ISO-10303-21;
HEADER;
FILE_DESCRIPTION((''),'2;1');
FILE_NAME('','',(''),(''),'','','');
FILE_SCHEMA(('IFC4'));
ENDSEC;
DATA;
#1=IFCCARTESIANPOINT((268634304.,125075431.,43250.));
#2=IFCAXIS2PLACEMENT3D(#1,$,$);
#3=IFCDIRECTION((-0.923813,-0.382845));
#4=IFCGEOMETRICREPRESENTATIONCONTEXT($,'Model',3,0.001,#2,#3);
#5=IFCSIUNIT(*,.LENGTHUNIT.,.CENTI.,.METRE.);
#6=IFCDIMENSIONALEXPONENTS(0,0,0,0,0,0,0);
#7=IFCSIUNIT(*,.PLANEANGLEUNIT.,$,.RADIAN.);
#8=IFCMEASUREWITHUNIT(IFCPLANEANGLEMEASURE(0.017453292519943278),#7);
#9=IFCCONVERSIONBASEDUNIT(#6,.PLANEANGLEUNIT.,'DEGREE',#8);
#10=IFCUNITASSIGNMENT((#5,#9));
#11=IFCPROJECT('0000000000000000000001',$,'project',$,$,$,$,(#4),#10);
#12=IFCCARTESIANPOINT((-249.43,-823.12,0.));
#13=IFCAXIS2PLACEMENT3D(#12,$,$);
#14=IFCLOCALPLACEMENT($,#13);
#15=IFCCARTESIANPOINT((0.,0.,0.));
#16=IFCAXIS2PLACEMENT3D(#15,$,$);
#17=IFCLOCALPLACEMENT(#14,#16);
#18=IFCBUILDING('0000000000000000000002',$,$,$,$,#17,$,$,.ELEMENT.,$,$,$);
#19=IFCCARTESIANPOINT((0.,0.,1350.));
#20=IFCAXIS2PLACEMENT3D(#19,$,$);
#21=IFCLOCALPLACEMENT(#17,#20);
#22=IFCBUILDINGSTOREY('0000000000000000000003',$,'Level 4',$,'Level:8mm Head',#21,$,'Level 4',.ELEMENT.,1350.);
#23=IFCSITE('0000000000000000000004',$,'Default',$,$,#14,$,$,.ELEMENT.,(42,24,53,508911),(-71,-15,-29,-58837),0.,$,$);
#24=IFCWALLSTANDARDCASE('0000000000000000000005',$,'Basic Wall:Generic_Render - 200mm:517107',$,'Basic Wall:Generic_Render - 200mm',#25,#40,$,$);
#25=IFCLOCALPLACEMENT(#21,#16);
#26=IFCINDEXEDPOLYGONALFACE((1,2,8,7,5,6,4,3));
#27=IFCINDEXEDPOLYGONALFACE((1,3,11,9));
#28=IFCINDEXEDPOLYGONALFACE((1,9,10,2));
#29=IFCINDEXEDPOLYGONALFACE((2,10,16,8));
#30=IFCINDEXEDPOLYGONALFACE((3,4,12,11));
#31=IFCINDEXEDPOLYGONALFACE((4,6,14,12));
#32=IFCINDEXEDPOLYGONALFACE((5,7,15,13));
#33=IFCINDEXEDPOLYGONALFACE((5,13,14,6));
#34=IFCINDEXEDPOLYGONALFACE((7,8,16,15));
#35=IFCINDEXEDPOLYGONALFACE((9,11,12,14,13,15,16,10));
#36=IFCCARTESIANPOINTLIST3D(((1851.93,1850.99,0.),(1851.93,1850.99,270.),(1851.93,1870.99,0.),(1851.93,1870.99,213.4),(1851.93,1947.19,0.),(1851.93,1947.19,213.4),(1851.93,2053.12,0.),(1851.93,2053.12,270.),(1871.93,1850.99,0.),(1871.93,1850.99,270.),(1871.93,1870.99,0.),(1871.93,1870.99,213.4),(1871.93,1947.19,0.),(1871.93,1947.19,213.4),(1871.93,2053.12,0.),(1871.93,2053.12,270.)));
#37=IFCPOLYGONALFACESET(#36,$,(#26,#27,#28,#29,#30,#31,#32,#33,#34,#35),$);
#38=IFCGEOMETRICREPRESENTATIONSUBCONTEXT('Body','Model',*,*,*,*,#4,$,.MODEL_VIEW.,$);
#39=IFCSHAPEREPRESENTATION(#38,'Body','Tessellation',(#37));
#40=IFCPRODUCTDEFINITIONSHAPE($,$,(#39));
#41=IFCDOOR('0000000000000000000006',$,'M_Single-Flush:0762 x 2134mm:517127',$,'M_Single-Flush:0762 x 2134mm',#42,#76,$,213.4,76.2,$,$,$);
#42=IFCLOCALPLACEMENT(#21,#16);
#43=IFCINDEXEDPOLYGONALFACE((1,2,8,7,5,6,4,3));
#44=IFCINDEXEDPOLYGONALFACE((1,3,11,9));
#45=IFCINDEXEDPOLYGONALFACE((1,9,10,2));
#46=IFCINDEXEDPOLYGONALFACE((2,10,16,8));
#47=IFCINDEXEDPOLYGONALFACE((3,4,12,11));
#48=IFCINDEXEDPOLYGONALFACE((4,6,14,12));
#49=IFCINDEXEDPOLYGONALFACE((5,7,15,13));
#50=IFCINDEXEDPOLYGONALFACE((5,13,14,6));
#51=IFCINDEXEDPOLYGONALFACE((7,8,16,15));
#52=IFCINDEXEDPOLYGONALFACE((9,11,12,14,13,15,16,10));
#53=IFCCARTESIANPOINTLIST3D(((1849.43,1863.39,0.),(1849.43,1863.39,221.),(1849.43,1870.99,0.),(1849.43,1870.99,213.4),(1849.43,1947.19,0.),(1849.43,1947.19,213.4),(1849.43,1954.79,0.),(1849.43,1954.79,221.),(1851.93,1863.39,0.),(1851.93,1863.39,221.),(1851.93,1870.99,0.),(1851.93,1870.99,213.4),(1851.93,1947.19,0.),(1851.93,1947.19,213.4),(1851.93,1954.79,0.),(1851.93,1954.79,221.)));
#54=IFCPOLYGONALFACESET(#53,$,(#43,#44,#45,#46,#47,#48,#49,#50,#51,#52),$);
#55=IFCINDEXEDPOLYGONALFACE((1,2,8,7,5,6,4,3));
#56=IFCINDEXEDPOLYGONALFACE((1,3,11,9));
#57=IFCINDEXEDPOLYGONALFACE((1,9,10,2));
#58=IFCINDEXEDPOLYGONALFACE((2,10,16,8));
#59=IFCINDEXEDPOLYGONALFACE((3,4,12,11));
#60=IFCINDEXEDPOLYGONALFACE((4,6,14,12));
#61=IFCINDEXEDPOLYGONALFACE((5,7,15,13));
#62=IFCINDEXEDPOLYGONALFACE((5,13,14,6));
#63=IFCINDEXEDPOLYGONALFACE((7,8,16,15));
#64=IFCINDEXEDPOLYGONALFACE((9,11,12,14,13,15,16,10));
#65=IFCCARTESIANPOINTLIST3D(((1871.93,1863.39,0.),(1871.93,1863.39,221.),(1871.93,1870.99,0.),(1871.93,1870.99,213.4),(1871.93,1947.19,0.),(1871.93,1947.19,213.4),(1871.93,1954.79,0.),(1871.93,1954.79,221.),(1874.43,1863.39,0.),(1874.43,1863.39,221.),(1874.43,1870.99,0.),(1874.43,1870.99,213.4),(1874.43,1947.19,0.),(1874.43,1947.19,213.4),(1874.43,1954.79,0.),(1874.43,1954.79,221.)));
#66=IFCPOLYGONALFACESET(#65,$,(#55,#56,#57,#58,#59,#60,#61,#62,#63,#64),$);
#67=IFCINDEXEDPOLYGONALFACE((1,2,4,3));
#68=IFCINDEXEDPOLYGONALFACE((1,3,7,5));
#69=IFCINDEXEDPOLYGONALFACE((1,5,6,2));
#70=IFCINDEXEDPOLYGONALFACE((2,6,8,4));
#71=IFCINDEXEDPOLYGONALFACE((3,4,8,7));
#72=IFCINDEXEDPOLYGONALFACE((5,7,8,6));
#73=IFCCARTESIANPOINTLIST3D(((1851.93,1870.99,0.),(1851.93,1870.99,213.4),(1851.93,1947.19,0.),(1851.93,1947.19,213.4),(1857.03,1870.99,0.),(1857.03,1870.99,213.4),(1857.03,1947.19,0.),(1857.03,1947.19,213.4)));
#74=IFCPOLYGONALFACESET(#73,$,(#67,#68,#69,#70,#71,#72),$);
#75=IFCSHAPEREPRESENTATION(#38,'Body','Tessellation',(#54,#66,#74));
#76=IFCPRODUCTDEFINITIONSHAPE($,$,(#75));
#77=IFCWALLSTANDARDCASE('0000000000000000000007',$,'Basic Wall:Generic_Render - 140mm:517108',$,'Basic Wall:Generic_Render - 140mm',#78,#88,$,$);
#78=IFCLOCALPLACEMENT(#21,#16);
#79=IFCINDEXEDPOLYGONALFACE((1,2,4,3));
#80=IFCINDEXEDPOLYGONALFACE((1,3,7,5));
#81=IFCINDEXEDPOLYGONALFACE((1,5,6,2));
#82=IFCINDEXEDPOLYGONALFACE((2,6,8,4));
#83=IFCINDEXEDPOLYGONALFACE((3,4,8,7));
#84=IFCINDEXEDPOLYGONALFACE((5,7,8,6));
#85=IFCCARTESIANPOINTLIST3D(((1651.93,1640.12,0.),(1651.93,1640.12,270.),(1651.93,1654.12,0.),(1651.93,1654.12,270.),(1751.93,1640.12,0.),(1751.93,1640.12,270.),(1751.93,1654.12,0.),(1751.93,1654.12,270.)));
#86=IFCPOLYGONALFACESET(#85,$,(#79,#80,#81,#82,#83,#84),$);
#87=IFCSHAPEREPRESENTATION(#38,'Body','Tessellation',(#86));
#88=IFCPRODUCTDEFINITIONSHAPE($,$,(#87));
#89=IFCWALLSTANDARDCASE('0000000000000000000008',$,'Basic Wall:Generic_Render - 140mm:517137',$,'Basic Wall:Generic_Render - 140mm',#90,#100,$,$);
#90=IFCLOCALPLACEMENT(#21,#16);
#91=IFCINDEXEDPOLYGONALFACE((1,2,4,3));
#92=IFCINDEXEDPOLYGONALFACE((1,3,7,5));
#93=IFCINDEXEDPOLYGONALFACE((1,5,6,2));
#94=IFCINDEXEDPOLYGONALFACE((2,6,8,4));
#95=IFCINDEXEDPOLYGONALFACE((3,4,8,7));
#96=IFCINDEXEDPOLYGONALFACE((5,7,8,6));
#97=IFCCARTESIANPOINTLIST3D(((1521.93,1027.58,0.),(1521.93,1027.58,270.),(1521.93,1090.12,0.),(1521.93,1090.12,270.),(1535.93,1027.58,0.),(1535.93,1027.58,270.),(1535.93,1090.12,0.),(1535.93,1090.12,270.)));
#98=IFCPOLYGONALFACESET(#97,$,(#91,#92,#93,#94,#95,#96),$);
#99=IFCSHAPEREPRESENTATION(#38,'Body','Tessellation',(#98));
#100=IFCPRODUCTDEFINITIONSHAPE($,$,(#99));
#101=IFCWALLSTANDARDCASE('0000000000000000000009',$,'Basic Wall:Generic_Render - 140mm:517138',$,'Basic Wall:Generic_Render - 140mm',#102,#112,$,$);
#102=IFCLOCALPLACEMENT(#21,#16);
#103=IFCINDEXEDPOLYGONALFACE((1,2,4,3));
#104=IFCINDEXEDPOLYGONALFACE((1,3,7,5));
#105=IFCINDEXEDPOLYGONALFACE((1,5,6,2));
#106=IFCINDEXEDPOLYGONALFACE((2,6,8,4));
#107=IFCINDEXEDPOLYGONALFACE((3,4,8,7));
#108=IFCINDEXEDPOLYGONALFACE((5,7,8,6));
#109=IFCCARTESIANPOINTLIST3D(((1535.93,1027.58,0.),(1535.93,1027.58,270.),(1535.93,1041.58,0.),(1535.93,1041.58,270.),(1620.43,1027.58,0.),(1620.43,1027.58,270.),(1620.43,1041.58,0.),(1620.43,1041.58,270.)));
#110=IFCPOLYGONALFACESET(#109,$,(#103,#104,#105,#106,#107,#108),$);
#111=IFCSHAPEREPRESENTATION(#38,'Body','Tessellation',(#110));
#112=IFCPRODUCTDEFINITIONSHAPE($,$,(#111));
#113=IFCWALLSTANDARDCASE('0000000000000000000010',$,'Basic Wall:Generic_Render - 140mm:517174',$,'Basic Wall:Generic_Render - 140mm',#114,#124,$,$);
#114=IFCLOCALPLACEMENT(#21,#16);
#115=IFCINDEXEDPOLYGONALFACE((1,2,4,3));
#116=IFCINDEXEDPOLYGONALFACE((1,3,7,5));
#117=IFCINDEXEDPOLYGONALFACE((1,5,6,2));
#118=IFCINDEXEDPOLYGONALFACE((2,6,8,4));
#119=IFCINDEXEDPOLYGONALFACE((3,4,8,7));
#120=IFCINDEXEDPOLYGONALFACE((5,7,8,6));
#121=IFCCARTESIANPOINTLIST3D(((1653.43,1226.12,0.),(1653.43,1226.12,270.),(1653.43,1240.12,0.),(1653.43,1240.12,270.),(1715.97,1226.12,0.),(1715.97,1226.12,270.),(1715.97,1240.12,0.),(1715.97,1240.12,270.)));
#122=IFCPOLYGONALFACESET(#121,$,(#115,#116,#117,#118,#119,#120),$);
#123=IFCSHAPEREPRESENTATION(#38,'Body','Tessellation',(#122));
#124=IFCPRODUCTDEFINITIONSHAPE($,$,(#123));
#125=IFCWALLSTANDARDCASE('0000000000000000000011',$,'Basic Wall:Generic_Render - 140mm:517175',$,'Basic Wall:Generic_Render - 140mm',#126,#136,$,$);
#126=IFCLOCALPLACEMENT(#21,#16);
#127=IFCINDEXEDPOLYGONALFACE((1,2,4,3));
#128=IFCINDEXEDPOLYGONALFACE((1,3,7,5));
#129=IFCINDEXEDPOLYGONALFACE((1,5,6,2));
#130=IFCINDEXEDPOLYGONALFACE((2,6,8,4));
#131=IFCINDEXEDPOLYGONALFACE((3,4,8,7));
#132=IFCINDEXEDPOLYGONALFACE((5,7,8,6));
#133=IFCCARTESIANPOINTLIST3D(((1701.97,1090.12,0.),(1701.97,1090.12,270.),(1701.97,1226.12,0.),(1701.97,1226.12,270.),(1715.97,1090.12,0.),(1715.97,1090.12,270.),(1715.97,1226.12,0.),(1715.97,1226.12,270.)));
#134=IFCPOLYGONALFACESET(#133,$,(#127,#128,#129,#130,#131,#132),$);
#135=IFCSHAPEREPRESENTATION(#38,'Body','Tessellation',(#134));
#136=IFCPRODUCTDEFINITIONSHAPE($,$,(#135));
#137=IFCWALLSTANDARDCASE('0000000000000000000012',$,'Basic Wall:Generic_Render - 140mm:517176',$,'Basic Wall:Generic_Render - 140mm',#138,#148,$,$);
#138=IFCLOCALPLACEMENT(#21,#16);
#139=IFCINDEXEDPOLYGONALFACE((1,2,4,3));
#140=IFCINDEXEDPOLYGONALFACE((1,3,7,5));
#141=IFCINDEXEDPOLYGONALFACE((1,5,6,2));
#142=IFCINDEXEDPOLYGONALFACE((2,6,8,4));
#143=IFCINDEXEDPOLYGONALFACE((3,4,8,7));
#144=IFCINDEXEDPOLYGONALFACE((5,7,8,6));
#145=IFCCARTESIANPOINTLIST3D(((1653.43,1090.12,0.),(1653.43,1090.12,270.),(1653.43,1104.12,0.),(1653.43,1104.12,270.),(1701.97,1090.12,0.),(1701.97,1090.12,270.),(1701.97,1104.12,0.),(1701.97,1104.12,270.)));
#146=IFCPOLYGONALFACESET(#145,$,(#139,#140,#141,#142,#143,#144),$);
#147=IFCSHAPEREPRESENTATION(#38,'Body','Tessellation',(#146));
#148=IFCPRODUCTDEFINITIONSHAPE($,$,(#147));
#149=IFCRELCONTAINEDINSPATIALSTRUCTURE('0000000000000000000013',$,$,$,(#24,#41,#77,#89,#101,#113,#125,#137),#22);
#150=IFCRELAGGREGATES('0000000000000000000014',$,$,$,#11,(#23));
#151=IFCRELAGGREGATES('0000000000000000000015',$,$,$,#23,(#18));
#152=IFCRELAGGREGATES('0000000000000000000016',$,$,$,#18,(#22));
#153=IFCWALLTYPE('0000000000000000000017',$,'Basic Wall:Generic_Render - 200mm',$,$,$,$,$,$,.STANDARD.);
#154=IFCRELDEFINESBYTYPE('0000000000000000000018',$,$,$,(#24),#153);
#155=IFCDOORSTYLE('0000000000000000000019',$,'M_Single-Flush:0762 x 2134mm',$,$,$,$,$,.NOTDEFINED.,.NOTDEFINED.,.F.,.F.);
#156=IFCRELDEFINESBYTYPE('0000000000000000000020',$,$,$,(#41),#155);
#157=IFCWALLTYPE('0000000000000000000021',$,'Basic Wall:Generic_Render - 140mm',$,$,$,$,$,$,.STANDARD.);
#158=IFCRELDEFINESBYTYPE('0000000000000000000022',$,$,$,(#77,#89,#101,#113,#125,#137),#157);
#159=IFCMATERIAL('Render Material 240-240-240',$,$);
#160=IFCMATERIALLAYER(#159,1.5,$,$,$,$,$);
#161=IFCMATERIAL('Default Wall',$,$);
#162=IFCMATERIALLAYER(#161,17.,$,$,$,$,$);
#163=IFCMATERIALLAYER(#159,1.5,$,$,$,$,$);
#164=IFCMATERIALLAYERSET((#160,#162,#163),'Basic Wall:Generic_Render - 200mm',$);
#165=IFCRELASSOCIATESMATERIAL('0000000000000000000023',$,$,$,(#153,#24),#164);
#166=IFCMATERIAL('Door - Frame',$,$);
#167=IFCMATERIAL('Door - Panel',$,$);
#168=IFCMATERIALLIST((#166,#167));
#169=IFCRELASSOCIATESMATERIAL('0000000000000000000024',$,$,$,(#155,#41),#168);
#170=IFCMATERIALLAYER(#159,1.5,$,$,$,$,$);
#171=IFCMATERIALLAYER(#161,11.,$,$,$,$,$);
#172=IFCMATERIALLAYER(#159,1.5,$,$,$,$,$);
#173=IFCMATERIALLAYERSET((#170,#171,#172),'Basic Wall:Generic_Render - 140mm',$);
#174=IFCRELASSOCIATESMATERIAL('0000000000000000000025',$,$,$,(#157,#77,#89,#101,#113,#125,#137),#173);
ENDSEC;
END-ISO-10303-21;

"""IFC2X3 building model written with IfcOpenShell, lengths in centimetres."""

from ifc_helpers import new_model, entity, si_unit, converted_unit, direction, frame, frame_2d, origin, place, context, subcontext, project, spatial, polyline, rectangle, outline, extrude, source, transform, mapped, material, material_list, layer, layer_set, layer_usage, type_object, type_shapes, element, fill, save


model = new_model("IFC2X3")

# Units and contexts
model_context = context("Model", 3, precision=0.001, world=frame((268634304.0, 125075431.0, 43250.0)), true_north=direction((-0.923813, -0.382845)))
body_context = subcontext(model_context, "Body", "Model", "MODEL_VIEW")
ifc_project = project(units=[si_unit("LENGTHUNIT", "METRE", prefix="CENTI"), converted_unit("PLANEANGLEUNIT", "DEGREE", entity("IfcPlaneAngleMeasure", 0.017453292519943278), si_unit("PLANEANGLEUNIT", "RADIAN"), dimensions=[0, 0, 0, 0, 0, 0, 0])], contexts=[model_context])

# Site, building, storey
site_placement = place(None, frame((-249.43, -823.12, 0.0)))
site = spatial("IfcSite", under=ifc_project, at=site_placement, Name="Default", CompositionType="ELEMENT", RefLatitude=(42, 24, 53, 508911), RefLongitude=(-71, -15, -29, -58837), RefElevation=0.0)
building_placement = place(site_placement, origin())
building = spatial("IfcBuilding", under=site, at=building_placement, CompositionType="ELEMENT")
storey_placement = place(building_placement, frame((0.0, 0.0, 1350.0)))
storey = spatial("IfcBuildingStorey", under=building, at=storey_placement, Name="Level 4", ObjectType="Level:8mm Head", LongName="Level 4", CompositionType="ELEMENT", Elevation=1350.0)

# Shared definitions
ifc_material_1 = material(Name="Render Material 240-240-240")
ifc_material_2 = material(Name="Default Wall")
ifc_layer_1 = layer(ifc_material_1, 1.5)
ifc_layer_2 = layer(ifc_material_2, 17.0)
ifc_layer_3 = layer(ifc_material_1, 1.5)
ifc_layer_set_1 = layer_set([ifc_layer_1, ifc_layer_2, ifc_layer_3], Name="Basic Wall:Generic_Render - 200mm")
wall_type_1 = type_object("IfcWallType", Name="Basic Wall:Generic_Render - 200mm", PredefinedType="STANDARD", material=ifc_layer_set_1)

# Shared definitions
ifc_material_3 = material(Name="Door - Frame")
ifc_material_4 = material(Name="Door - Panel")
ifc_material_list_1 = material_list([ifc_material_3, ifc_material_4])

# Wall, opening, door
ifc_layer_usage_1 = layer_usage(ifc_layer_set_1, "AXIS2", "NEGATIVE", 10.0)
wall_1_placement = place(storey_placement, frame((1861.93, 1850.99, 0.0), z_axis=(0.0, 0.0, 1.0), x_axis=(0.0, 1.0, 0.0)))
wall_1 = element("IfcWallStandardCase", 1, at=wall_1_placement, inside=storey, type_object=wall_type_1, material=ifc_layer_usage_1, Name="Basic Wall:Generic_Render - 200mm:517107", ObjectType="Basic Wall:Generic_Render - 200mm", context=body_context, shape_type="SweptSolid", body=[
    extrude(rectangle(XDim=202.14, YDim=20.0, at=frame_2d((101.07, 0.0), x_axis=(1.0, 0.0))), origin(), (0.0, 0.0, 1.0), 270.0),
])
opening_1_placement = place(wall_1_placement, frame((20.0, -10.0, 0.0)))
opening_1 = element("IfcOpeningElement", 2, at=opening_1_placement, cuts=wall_1, ObjectType="Opening", context=body_context, shape_type="SweptSolid", body=[
    extrude(rectangle(XDim=76.2, YDim=213.4, at=frame_2d((106.7, 38.1), x_axis=(0.0, -1.0))), frame((0.0, 0.0, 0.0), z_axis=(0.0, 1.0, 0.0), x_axis=(0.0, 0.0, 1.0)), (0.0, 0.0, 1.0), 20.0),
])
door_style_1 = type_object("IfcDoorStyle", Name="M_Single-Flush:0762 x 2134mm", ConstructionType="NOTDEFINED", OperationType="NOTDEFINED", ParameterTakesPrecedence=False, Sizeable=False, material=ifc_material_list_1)
shared_shape_1 = source(origin(), body_context, "Body", "SweptSolid", [
    extrude(outline(polyline([(-45.7, -112.4), (45.7, -112.4), (45.7, 108.6), (38.1, 108.6), (38.1, -104.8), (-38.1, -104.8), (-38.1, 108.6), (-45.7, 108.6), (-45.7, -112.4)])), frame((38.1, 22.5, 108.6), z_axis=(0.0, -1.0, 0.0), x_axis=(-1.0, 0.0, 0.0)), (0.0, 0.0, 1.0), 2.5),
    extrude(outline(polyline([(-112.4, -45.7), (108.6, -45.7), (108.6, -38.1), (-104.8, -38.1), (-104.8, 38.1), (108.6, 38.1), (108.6, 45.7), (-112.4, 45.7), (-112.4, -45.7)])), frame((38.1, 0.0, 108.6), z_axis=(0.0, -1.0, 0.0), x_axis=(0.0, 0.0, -1.0)), (0.0, 0.0, 1.0), 2.5),
    extrude(rectangle(XDim=76.2, YDim=5.1, at=frame_2d((0.0, 0.0), x_axis=(1.0, 0.0))), frame((38.1, 17.45, 0.0)), (0.0, 0.0, 1.0), 213.4),
])
type_shapes(door_style_1, [shared_shape_1])
door_1_placement = place(opening_1_placement, origin())
door_1 = element("IfcDoor", 3, at=door_1_placement, inside=storey, type_object=door_style_1, material=ifc_material_list_1, Name="M_Single-Flush:0762 x 2134mm:517127", ObjectType="M_Single-Flush:0762 x 2134mm", OverallHeight=213.4, OverallWidth=76.2, context=body_context, shape_type="MappedRepresentation", body=[
    mapped(shared_shape_1, transform((0.0, 0.0, 0.0), scale=1.0)),
])
fill(opening_1, door_1)

# Walls
ifc_layer_4 = layer(ifc_material_1, 1.5)
ifc_layer_5 = layer(ifc_material_2, 11.0)
ifc_layer_6 = layer(ifc_material_1, 1.5)
ifc_layer_set_2 = layer_set([ifc_layer_4, ifc_layer_5, ifc_layer_6], Name="Basic Wall:Generic_Render - 140mm")
ifc_layer_usage_2 = layer_usage(ifc_layer_set_2, "AXIS2", "NEGATIVE", 7.0)
wall_type_2 = type_object("IfcWallType", Name="Basic Wall:Generic_Render - 140mm", PredefinedType="STANDARD", material=ifc_layer_set_2)
wall_2_placement = place(storey_placement, frame((1651.93, 1647.12, 0.0)))
element("IfcWallStandardCase", 4, at=wall_2_placement, inside=storey, type_object=wall_type_2, material=ifc_layer_usage_2, Name="Basic Wall:Generic_Render - 140mm:517108", ObjectType="Basic Wall:Generic_Render - 140mm", context=body_context, shape_type="SweptSolid", body=[
    extrude(rectangle(XDim=100.0, YDim=14.0, at=frame_2d((50.0, 0.0), x_axis=(-1.0, 0.0))), origin(), (0.0, 0.0, 1.0), 270.0),
])
ifc_layer_usage_3 = layer_usage(ifc_layer_set_2, "AXIS2", "POSITIVE", -7.0)
wall_3_placement = place(storey_placement, frame((1528.93, 1090.12, 0.0), z_axis=(0.0, 0.0, 1.0), x_axis=(0.0, -1.0, 0.0)))
element("IfcWallStandardCase", 5, at=wall_3_placement, inside=storey, type_object=wall_type_2, material=ifc_layer_usage_3, Name="Basic Wall:Generic_Render - 140mm:517137", ObjectType="Basic Wall:Generic_Render - 140mm", context=body_context, shape_type="SweptSolid", body=[
    extrude(rectangle(XDim=62.54, YDim=14.0, at=frame_2d((31.27, 0.0), x_axis=(-1.0, 0.0))), origin(), (0.0, 0.0, 1.0), 270.0),
])
ifc_layer_usage_4 = layer_usage(ifc_layer_set_2, "AXIS2", "POSITIVE", -7.0)
wall_4_placement = place(storey_placement, frame((1535.93, 1034.58, 0.0)))
element("IfcWallStandardCase", 6, at=wall_4_placement, inside=storey, type_object=wall_type_2, material=ifc_layer_usage_4, Name="Basic Wall:Generic_Render - 140mm:517138", ObjectType="Basic Wall:Generic_Render - 140mm", context=body_context, shape_type="SweptSolid", body=[
    extrude(rectangle(XDim=84.5, YDim=14.0, at=frame_2d((42.25, 0.0), x_axis=(-1.0, 0.0))), origin(), (0.0, 0.0, 1.0), 270.0),
])
ifc_layer_usage_5 = layer_usage(ifc_layer_set_2, "AXIS2", "NEGATIVE", 7.0)
wall_5_placement = place(storey_placement, frame((1653.43, 1233.12, 0.0)))
element("IfcWallStandardCase", 7, at=wall_5_placement, inside=storey, type_object=wall_type_2, material=ifc_layer_usage_5, Name="Basic Wall:Generic_Render - 140mm:517174", ObjectType="Basic Wall:Generic_Render - 140mm", context=body_context, shape_type="SweptSolid", body=[
    extrude(rectangle(XDim=62.54, YDim=14.0, at=frame_2d((31.27, 0.0), x_axis=(-1.0, 0.0))), origin(), (0.0, 0.0, 1.0), 270.0),
])
ifc_layer_usage_6 = layer_usage(ifc_layer_set_2, "AXIS2", "NEGATIVE", 7.0)
wall_6_placement = place(storey_placement, frame((1708.97, 1226.12, 0.0), z_axis=(0.0, 0.0, 1.0), x_axis=(0.0, -1.0, 0.0)))
element("IfcWallStandardCase", 8, at=wall_6_placement, inside=storey, type_object=wall_type_2, material=ifc_layer_usage_6, Name="Basic Wall:Generic_Render - 140mm:517175", ObjectType="Basic Wall:Generic_Render - 140mm", context=body_context, shape_type="SweptSolid", body=[
    extrude(rectangle(XDim=136.0, YDim=14.0, at=frame_2d((68.0, 0.0), x_axis=(-1.0, 0.0))), origin(), (0.0, 0.0, 1.0), 270.0),
])
ifc_layer_usage_7 = layer_usage(ifc_layer_set_2, "AXIS2", "NEGATIVE", 7.0)
wall_7_placement = place(storey_placement, frame((1701.97, 1097.12, 0.0), z_axis=(0.0, 0.0, 1.0), x_axis=(-1.0, 0.0, 0.0)))
element("IfcWallStandardCase", 9, at=wall_7_placement, inside=storey, type_object=wall_type_2, material=ifc_layer_usage_7, Name="Basic Wall:Generic_Render - 140mm:517176", ObjectType="Basic Wall:Generic_Render - 140mm", context=body_context, shape_type="SweptSolid", body=[
    extrude(rectangle(XDim=48.54, YDim=14.0, at=frame_2d((24.27, 0.0), x_axis=(-1.0, 0.0))), origin(), (0.0, 0.0, 1.0), 270.0),
])

save(model, "model.ifc")
